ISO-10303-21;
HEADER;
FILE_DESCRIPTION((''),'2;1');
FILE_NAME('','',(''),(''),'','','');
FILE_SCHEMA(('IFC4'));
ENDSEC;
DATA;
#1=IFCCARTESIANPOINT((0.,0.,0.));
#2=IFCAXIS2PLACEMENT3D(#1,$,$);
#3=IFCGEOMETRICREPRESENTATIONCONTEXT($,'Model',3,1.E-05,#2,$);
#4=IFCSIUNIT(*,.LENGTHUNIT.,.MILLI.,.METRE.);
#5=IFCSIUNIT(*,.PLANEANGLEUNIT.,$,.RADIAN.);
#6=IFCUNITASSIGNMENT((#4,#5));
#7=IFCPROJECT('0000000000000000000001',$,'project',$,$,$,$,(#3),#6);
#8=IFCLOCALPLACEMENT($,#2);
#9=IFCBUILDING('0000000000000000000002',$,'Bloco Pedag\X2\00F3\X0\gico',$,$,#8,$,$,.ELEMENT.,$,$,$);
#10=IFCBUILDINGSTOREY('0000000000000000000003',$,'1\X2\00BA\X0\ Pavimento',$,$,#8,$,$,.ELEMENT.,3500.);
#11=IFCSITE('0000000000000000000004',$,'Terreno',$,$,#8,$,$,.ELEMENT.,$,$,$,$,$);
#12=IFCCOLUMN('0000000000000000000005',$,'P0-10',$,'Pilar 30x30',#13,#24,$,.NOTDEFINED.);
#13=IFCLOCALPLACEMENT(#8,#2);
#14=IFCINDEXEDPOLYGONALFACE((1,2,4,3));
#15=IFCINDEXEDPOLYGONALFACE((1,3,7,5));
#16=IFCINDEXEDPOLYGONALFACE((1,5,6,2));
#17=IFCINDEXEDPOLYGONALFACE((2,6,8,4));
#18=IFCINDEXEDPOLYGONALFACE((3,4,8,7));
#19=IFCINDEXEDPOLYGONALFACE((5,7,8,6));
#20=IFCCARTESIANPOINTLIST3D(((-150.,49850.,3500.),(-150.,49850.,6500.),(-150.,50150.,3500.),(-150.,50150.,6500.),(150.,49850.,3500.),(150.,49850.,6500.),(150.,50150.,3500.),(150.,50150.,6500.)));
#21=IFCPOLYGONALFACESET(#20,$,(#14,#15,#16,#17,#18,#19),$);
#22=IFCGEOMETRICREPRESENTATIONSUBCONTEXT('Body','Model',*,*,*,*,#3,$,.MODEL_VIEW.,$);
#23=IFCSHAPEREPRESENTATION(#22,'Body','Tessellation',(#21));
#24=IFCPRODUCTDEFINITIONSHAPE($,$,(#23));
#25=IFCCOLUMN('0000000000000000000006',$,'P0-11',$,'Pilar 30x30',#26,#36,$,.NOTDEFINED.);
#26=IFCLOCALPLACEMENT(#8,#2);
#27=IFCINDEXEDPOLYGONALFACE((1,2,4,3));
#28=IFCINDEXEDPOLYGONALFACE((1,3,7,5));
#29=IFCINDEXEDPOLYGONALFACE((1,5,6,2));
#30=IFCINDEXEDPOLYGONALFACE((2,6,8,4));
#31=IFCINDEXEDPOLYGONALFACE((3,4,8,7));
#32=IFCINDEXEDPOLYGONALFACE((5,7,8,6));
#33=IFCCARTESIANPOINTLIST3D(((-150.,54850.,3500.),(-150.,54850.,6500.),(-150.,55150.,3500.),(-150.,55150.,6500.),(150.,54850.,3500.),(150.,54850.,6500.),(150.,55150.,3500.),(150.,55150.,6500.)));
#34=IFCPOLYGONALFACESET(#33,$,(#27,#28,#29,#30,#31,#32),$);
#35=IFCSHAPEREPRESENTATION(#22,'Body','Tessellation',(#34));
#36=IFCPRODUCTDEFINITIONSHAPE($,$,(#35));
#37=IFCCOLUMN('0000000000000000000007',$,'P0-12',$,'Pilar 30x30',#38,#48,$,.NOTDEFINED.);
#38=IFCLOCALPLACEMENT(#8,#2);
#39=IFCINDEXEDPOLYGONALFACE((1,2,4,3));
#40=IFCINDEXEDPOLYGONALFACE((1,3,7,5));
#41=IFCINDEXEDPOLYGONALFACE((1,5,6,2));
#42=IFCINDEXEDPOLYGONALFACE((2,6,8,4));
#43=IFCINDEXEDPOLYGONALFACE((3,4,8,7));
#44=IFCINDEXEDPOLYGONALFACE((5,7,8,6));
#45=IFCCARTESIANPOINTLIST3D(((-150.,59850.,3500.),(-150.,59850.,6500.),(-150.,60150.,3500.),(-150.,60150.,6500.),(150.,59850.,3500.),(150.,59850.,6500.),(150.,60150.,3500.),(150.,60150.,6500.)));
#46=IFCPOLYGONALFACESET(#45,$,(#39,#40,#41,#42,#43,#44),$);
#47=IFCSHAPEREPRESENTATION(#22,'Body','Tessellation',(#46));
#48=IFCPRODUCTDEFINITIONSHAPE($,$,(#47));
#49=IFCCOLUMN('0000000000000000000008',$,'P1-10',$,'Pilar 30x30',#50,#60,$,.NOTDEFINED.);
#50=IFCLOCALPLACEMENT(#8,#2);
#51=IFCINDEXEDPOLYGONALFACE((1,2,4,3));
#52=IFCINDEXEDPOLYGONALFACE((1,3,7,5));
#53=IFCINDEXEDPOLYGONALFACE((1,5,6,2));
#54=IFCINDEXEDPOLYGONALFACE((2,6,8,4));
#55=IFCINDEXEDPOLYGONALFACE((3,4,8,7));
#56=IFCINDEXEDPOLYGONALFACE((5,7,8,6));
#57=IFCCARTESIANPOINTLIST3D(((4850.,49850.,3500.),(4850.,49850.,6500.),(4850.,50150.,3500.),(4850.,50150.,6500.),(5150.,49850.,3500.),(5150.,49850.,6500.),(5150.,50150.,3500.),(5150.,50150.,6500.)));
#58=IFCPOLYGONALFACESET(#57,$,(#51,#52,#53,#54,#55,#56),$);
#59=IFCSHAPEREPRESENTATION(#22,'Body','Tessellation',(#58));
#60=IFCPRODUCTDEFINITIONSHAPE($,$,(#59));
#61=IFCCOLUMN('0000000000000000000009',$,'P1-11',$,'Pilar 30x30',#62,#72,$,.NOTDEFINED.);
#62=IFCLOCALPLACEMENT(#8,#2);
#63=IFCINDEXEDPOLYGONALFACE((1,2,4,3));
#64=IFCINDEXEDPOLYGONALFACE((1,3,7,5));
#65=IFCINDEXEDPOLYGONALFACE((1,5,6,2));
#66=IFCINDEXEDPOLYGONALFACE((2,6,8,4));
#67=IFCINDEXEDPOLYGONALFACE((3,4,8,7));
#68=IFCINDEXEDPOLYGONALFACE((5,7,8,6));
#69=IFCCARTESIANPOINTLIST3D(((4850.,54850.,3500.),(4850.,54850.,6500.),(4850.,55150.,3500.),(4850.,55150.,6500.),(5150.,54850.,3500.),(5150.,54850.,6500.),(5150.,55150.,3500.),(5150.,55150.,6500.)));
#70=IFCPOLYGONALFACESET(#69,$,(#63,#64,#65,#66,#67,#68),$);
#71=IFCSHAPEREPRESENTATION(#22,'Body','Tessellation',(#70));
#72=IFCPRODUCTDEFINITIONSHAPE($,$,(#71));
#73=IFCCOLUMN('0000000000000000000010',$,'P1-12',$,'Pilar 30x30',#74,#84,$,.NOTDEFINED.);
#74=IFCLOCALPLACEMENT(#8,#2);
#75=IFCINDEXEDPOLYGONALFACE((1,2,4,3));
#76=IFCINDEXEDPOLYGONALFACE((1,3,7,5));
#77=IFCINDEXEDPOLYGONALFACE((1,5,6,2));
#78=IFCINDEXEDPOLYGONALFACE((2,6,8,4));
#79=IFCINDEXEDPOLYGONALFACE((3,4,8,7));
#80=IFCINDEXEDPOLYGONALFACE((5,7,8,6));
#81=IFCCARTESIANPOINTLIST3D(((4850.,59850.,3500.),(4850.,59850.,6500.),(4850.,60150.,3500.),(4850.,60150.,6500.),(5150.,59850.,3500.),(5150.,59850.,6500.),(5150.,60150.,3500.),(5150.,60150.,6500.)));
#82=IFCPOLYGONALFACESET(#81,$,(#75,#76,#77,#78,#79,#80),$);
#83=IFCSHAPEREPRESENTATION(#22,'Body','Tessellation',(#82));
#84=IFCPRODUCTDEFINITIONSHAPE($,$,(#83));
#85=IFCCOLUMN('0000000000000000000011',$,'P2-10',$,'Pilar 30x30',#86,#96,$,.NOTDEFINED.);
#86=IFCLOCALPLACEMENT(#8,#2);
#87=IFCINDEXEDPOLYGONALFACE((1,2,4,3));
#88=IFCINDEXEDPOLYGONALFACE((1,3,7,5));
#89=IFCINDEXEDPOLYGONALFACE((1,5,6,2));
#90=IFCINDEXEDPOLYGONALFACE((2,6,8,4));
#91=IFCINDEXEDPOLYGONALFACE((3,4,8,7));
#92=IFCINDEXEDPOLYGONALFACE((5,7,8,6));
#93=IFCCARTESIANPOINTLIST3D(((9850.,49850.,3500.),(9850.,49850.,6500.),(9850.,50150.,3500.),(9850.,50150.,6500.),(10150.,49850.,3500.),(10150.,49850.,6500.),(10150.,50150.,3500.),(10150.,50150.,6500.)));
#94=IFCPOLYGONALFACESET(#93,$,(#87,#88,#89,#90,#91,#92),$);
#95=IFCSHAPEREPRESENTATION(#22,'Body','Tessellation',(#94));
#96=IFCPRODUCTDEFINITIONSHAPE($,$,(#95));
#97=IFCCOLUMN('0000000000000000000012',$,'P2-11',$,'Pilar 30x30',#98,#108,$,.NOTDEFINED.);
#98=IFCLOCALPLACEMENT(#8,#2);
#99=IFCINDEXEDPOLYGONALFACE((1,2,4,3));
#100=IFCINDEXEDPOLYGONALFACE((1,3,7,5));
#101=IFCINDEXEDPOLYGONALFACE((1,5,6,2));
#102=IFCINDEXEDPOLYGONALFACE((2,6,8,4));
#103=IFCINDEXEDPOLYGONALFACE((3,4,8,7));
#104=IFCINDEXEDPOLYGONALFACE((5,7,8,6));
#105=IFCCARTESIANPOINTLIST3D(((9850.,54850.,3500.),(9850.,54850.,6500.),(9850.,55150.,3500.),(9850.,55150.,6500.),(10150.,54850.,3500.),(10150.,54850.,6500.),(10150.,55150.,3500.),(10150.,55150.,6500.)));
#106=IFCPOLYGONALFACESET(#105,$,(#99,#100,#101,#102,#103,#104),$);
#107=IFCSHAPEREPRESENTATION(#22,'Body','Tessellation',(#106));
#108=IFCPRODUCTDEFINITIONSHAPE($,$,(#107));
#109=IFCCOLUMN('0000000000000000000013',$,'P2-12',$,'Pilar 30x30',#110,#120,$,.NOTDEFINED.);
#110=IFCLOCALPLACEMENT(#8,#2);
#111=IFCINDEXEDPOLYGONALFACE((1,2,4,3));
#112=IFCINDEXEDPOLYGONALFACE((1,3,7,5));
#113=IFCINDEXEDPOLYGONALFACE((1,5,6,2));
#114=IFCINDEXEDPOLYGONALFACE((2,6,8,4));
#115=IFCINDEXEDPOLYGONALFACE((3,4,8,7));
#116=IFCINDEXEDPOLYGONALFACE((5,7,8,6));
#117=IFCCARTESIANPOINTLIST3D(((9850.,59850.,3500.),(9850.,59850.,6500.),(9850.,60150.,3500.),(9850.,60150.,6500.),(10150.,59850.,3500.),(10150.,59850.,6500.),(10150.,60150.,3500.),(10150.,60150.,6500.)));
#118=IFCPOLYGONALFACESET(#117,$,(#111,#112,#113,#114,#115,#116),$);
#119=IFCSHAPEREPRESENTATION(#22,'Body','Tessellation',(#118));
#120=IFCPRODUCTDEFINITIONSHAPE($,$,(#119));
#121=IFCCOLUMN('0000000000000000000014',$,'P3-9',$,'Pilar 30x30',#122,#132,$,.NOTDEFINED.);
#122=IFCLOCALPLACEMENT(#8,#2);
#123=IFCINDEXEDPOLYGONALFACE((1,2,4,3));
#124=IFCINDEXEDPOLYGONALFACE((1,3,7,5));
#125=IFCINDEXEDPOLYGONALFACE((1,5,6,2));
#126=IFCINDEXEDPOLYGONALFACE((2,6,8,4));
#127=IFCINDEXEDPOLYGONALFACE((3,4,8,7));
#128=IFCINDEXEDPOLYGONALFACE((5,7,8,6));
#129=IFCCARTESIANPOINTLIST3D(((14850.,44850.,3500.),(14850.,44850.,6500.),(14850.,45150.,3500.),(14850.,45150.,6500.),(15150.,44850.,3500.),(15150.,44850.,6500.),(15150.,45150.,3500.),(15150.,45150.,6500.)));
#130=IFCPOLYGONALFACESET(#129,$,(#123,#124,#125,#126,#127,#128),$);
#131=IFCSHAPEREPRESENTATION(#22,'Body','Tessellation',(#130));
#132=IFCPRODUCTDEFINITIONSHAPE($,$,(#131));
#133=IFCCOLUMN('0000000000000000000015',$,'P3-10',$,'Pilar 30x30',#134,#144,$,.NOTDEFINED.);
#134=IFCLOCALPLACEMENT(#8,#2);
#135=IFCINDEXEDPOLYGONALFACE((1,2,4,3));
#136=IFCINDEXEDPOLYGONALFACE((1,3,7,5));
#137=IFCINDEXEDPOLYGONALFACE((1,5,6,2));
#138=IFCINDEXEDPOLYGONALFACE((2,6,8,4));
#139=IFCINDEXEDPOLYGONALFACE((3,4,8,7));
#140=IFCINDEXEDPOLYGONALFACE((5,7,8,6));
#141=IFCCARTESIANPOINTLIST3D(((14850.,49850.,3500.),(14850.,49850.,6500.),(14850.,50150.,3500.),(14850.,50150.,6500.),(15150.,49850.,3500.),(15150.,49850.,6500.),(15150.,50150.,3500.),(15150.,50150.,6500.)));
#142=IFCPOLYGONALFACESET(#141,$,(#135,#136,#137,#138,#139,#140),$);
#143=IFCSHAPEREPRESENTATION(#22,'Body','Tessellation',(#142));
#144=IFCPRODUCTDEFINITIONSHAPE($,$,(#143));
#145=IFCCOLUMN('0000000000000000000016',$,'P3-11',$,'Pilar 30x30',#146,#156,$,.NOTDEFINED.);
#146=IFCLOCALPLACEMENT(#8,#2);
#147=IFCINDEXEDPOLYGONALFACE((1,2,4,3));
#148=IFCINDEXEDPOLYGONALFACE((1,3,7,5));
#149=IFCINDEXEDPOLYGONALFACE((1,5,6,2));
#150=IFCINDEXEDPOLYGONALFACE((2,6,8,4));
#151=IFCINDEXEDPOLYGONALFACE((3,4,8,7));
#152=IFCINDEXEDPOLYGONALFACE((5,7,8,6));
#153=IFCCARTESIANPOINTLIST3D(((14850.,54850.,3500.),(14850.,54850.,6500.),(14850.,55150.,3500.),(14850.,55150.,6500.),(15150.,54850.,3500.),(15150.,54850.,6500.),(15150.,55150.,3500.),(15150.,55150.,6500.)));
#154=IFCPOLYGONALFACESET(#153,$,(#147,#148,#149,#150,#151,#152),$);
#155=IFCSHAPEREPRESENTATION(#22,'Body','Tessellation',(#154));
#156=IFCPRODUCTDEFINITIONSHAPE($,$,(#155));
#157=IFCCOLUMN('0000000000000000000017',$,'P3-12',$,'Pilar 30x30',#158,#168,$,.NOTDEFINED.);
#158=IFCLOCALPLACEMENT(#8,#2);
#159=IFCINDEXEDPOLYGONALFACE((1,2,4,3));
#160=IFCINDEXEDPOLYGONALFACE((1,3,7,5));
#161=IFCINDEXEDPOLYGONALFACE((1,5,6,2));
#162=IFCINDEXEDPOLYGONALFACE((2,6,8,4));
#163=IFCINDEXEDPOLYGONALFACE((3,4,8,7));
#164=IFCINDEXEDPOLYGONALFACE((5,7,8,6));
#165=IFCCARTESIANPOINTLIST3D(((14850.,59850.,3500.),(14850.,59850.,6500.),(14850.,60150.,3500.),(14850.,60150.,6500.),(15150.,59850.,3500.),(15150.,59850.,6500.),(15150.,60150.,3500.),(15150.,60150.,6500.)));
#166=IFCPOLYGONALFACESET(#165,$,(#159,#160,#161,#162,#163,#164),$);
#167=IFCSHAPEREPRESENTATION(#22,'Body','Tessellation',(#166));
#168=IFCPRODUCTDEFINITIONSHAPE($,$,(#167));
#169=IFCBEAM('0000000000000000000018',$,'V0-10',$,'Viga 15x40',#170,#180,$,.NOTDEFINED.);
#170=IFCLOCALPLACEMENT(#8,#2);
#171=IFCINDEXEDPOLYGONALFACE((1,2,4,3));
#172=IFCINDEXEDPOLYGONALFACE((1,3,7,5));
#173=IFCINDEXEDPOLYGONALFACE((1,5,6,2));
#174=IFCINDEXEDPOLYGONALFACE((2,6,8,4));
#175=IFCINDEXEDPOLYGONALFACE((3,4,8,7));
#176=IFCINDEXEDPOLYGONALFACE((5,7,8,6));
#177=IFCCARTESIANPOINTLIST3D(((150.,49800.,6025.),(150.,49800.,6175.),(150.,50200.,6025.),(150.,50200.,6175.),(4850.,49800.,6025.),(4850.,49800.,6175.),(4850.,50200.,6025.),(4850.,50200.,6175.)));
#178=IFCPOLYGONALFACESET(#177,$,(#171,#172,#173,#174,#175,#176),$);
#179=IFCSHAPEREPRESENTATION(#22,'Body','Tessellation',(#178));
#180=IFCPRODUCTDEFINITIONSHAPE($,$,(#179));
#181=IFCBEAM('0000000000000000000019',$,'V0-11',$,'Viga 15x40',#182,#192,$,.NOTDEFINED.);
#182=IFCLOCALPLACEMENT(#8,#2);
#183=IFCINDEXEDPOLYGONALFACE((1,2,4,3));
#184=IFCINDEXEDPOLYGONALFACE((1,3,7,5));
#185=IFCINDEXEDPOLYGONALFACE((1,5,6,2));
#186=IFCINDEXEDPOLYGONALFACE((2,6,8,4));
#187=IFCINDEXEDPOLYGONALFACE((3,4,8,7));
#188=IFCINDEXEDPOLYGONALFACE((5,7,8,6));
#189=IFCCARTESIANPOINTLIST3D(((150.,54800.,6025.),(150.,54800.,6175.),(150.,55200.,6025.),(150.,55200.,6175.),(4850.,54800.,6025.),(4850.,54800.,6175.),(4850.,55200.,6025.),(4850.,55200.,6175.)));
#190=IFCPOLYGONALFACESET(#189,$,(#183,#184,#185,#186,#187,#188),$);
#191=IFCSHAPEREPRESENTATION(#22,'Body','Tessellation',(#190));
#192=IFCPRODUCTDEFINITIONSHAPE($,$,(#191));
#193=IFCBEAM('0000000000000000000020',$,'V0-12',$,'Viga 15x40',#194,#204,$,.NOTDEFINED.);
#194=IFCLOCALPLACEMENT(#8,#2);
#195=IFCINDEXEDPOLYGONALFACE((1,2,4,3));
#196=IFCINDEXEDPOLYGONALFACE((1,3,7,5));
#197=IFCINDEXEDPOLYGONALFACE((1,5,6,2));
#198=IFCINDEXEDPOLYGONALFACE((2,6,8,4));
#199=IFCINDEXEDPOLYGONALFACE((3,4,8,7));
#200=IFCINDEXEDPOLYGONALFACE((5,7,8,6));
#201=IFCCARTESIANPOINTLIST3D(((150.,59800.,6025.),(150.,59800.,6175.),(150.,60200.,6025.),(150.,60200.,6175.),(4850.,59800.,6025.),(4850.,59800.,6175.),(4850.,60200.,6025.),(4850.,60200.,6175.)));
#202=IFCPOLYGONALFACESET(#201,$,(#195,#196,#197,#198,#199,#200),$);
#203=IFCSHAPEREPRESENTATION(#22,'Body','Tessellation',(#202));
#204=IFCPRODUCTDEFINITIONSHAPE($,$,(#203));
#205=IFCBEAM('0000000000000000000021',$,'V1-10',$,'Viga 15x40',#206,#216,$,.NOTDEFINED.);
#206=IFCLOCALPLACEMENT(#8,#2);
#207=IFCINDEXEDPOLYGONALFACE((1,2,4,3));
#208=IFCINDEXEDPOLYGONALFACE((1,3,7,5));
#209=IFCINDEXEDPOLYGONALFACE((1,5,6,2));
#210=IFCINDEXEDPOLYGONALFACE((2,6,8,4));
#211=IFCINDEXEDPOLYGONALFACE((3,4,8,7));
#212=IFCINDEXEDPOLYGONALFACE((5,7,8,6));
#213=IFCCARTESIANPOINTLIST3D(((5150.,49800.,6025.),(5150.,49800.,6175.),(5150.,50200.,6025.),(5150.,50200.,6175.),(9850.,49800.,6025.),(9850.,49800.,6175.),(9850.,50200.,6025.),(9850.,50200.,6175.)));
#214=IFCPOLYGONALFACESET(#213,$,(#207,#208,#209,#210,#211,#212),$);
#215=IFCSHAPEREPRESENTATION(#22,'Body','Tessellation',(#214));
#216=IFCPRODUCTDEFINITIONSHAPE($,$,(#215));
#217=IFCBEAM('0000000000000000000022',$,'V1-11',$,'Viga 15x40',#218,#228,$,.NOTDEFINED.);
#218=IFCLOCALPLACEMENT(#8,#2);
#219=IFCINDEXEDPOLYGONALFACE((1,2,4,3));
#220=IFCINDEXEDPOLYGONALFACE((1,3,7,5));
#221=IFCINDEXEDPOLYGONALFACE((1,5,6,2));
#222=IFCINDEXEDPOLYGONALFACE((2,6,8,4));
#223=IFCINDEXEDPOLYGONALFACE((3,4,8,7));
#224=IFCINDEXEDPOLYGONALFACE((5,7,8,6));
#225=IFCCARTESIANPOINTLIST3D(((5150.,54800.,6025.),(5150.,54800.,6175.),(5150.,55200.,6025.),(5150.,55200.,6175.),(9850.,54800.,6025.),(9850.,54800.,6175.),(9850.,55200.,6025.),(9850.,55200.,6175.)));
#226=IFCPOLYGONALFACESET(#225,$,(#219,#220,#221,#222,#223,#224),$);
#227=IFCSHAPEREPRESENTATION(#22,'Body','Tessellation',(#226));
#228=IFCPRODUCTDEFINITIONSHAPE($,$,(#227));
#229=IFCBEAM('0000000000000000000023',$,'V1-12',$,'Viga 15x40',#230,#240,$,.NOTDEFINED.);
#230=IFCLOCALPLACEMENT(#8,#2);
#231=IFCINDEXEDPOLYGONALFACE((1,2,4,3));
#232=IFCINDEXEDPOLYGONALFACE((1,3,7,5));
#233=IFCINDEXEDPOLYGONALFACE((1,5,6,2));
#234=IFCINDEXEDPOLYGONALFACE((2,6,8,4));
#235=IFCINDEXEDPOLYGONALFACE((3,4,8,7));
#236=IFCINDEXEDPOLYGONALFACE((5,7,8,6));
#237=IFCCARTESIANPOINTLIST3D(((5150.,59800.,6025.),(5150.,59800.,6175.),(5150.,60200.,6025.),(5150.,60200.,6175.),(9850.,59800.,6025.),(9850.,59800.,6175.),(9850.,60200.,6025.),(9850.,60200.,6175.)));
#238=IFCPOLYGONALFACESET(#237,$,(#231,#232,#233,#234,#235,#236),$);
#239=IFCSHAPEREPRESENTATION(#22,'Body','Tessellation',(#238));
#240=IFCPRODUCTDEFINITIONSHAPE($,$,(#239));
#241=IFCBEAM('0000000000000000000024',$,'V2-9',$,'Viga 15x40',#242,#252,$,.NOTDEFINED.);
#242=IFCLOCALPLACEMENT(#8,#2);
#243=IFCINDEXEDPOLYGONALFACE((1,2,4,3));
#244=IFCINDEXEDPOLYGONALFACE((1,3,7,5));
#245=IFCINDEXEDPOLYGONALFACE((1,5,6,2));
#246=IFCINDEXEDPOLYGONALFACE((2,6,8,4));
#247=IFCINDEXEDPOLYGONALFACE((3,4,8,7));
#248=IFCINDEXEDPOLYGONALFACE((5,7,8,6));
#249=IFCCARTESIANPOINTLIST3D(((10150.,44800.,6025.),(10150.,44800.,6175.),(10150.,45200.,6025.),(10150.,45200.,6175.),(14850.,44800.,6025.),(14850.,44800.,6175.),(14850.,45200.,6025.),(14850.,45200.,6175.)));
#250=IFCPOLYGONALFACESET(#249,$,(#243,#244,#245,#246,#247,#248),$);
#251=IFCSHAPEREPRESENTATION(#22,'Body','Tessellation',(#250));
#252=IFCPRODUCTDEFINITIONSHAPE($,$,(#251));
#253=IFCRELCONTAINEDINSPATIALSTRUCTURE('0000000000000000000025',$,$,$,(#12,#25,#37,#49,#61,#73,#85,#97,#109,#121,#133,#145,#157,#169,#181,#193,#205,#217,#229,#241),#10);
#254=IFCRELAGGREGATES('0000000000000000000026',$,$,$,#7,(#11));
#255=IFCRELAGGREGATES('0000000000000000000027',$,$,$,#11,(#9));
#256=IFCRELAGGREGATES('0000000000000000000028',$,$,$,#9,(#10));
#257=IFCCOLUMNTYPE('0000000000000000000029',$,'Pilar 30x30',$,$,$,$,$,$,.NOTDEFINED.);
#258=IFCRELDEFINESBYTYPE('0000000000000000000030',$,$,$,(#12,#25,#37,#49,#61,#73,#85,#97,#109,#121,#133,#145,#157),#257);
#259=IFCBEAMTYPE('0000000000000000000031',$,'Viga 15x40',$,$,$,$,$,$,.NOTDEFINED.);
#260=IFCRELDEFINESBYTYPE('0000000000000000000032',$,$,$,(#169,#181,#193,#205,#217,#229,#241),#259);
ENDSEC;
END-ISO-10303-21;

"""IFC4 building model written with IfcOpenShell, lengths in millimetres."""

from ifc_helpers import new_model, si_unit, frame, origin, origin_2d, place, context, subcontext, project, spatial, rectangle, extrude, type_object, element, save


model = new_model("IFC4")

# Units and contexts
model_context = context("Model", 3, precision=1e-05, world=origin())
body_context = subcontext(model_context, "Body", "Model", "MODEL_VIEW")
ifc_project = project(units=[si_unit("LENGTHUNIT", "METRE", prefix="MILLI"), si_unit("PLANEANGLEUNIT", "RADIAN")], contexts=[model_context])

# Site, building, storey
placement = place(None, origin())
site = spatial("IfcSite", under=ifc_project, at=placement, Name="Terreno", CompositionType="ELEMENT")
building = spatial("IfcBuilding", under=site, at=placement, Name="Bloco Pedagógico", CompositionType="ELEMENT")
storey = spatial("IfcBuildingStorey", under=building, at=placement, Name="1º Pavimento", CompositionType="ELEMENT", Elevation=3500.0)

# Columns
column_type = type_object("IfcColumnType", Name="Pilar 30x30", PredefinedType="NOTDEFINED")
for number, where, z_axis, x_axis, name in (
    (1, (0.0, 50000.0, 3500.0), (0.0, 0.0, 1.0), (1.0, 0.0, 0.0), "P0-10"),
    (2, (0.0, 55000.0, 3500.0), (0.0, 0.0, 1.0), (1.0, 0.0, 0.0), "P0-11"),
    (3, (0.0, 60000.0, 3500.0), (0.0, 0.0, 1.0), (1.0, 0.0, 0.0), "P0-12"),
    (4, (5000.0, 50000.0, 3500.0), (0.0, 0.0, 1.0), (1.0, 0.0, 0.0), "P1-10"),
    (5, (5000.0, 55000.0, 3500.0), (0.0, 0.0, 1.0), (1.0, 0.0, 0.0), "P1-11"),
    (6, (5000.0, 60000.0, 3500.0), (0.0, 0.0, 1.0), (1.0, 0.0, 0.0), "P1-12"),
    (7, (10000.0, 50000.0, 3500.0), (0.0, 0.0, 1.0), (1.0, 0.0, 0.0), "P2-10"),
    (8, (10000.0, 55000.0, 3500.0), (0.0, 0.0, 1.0), (1.0, 0.0, 0.0), "P2-11"),
    (9, (10000.0, 60000.0, 3500.0), (0.0, 0.0, 1.0), (1.0, 0.0, 0.0), "P2-12"),
    (10, (15000.0, 45000.0, 3500.0), (0.0, 0.0, 1.0), (1.0, 0.0, 0.0), "P3-9"),
    (11, (15000.0, 50000.0, 3500.0), (0.0, 0.0, 1.0), (1.0, 0.0, 0.0), "P3-10"),
    (12, (15000.0, 55000.0, 3500.0), (0.0, 0.0, 1.0), (1.0, 0.0, 0.0), "P3-11"),
    (13, (15000.0, 60000.0, 3500.0), (0.0, 0.0, 1.0), (1.0, 0.0, 0.0), "P3-12"),
):
    element("IfcColumn", number, at=place(None, frame(where, z_axis=z_axis, x_axis=x_axis)), inside=storey, type_object=column_type, Name=name, ObjectType="Pilar 30x30", PredefinedType="NOTDEFINED", context=body_context, shape_type="SweptSolid", body=[
        extrude(rectangle(XDim=300.0, YDim=300.0, at=origin_2d()), None, (0.0, 0.0, 1.0), 3000.0),
    ])

# Beams
beam_type = type_object("IfcBeamType", Name="Viga 15x40", PredefinedType="NOTDEFINED")
for number, where, z_axis, x_axis, name in (
    (14, (150.0, 50000.0, 6100.0), (1.0, 0.0, 0.0), (0.0, 1.0, 0.0), "V0-10"),
    (15, (150.0, 55000.0, 6100.0), (1.0, 0.0, 0.0), (0.0, 1.0, 0.0), "V0-11"),
    (16, (150.0, 60000.0, 6100.0), (1.0, 0.0, 0.0), (0.0, 1.0, 0.0), "V0-12"),
    (17, (5150.0, 50000.0, 6100.0), (1.0, 0.0, 0.0), (0.0, 1.0, 0.0), "V1-10"),
    (18, (5150.0, 55000.0, 6100.0), (1.0, 0.0, 0.0), (0.0, 1.0, 0.0), "V1-11"),
    (19, (5150.0, 60000.0, 6100.0), (1.0, 0.0, 0.0), (0.0, 1.0, 0.0), "V1-12"),
    (20, (10150.0, 45000.0, 6100.0), (1.0, 0.0, 0.0), (0.0, 1.0, 0.0), "V2-9"),
):
    element("IfcBeam", number, at=place(None, frame(where, z_axis=z_axis, x_axis=x_axis)), inside=storey, type_object=beam_type, Name=name, ObjectType="Viga 15x40", PredefinedType="NOTDEFINED", context=body_context, shape_type="SweptSolid", body=[
        extrude(rectangle(XDim=400.0, YDim=150.0, at=origin_2d()), None, (0.0, 0.0, 1.0), 4700.0),
    ])

save(model, "model.ifc")
